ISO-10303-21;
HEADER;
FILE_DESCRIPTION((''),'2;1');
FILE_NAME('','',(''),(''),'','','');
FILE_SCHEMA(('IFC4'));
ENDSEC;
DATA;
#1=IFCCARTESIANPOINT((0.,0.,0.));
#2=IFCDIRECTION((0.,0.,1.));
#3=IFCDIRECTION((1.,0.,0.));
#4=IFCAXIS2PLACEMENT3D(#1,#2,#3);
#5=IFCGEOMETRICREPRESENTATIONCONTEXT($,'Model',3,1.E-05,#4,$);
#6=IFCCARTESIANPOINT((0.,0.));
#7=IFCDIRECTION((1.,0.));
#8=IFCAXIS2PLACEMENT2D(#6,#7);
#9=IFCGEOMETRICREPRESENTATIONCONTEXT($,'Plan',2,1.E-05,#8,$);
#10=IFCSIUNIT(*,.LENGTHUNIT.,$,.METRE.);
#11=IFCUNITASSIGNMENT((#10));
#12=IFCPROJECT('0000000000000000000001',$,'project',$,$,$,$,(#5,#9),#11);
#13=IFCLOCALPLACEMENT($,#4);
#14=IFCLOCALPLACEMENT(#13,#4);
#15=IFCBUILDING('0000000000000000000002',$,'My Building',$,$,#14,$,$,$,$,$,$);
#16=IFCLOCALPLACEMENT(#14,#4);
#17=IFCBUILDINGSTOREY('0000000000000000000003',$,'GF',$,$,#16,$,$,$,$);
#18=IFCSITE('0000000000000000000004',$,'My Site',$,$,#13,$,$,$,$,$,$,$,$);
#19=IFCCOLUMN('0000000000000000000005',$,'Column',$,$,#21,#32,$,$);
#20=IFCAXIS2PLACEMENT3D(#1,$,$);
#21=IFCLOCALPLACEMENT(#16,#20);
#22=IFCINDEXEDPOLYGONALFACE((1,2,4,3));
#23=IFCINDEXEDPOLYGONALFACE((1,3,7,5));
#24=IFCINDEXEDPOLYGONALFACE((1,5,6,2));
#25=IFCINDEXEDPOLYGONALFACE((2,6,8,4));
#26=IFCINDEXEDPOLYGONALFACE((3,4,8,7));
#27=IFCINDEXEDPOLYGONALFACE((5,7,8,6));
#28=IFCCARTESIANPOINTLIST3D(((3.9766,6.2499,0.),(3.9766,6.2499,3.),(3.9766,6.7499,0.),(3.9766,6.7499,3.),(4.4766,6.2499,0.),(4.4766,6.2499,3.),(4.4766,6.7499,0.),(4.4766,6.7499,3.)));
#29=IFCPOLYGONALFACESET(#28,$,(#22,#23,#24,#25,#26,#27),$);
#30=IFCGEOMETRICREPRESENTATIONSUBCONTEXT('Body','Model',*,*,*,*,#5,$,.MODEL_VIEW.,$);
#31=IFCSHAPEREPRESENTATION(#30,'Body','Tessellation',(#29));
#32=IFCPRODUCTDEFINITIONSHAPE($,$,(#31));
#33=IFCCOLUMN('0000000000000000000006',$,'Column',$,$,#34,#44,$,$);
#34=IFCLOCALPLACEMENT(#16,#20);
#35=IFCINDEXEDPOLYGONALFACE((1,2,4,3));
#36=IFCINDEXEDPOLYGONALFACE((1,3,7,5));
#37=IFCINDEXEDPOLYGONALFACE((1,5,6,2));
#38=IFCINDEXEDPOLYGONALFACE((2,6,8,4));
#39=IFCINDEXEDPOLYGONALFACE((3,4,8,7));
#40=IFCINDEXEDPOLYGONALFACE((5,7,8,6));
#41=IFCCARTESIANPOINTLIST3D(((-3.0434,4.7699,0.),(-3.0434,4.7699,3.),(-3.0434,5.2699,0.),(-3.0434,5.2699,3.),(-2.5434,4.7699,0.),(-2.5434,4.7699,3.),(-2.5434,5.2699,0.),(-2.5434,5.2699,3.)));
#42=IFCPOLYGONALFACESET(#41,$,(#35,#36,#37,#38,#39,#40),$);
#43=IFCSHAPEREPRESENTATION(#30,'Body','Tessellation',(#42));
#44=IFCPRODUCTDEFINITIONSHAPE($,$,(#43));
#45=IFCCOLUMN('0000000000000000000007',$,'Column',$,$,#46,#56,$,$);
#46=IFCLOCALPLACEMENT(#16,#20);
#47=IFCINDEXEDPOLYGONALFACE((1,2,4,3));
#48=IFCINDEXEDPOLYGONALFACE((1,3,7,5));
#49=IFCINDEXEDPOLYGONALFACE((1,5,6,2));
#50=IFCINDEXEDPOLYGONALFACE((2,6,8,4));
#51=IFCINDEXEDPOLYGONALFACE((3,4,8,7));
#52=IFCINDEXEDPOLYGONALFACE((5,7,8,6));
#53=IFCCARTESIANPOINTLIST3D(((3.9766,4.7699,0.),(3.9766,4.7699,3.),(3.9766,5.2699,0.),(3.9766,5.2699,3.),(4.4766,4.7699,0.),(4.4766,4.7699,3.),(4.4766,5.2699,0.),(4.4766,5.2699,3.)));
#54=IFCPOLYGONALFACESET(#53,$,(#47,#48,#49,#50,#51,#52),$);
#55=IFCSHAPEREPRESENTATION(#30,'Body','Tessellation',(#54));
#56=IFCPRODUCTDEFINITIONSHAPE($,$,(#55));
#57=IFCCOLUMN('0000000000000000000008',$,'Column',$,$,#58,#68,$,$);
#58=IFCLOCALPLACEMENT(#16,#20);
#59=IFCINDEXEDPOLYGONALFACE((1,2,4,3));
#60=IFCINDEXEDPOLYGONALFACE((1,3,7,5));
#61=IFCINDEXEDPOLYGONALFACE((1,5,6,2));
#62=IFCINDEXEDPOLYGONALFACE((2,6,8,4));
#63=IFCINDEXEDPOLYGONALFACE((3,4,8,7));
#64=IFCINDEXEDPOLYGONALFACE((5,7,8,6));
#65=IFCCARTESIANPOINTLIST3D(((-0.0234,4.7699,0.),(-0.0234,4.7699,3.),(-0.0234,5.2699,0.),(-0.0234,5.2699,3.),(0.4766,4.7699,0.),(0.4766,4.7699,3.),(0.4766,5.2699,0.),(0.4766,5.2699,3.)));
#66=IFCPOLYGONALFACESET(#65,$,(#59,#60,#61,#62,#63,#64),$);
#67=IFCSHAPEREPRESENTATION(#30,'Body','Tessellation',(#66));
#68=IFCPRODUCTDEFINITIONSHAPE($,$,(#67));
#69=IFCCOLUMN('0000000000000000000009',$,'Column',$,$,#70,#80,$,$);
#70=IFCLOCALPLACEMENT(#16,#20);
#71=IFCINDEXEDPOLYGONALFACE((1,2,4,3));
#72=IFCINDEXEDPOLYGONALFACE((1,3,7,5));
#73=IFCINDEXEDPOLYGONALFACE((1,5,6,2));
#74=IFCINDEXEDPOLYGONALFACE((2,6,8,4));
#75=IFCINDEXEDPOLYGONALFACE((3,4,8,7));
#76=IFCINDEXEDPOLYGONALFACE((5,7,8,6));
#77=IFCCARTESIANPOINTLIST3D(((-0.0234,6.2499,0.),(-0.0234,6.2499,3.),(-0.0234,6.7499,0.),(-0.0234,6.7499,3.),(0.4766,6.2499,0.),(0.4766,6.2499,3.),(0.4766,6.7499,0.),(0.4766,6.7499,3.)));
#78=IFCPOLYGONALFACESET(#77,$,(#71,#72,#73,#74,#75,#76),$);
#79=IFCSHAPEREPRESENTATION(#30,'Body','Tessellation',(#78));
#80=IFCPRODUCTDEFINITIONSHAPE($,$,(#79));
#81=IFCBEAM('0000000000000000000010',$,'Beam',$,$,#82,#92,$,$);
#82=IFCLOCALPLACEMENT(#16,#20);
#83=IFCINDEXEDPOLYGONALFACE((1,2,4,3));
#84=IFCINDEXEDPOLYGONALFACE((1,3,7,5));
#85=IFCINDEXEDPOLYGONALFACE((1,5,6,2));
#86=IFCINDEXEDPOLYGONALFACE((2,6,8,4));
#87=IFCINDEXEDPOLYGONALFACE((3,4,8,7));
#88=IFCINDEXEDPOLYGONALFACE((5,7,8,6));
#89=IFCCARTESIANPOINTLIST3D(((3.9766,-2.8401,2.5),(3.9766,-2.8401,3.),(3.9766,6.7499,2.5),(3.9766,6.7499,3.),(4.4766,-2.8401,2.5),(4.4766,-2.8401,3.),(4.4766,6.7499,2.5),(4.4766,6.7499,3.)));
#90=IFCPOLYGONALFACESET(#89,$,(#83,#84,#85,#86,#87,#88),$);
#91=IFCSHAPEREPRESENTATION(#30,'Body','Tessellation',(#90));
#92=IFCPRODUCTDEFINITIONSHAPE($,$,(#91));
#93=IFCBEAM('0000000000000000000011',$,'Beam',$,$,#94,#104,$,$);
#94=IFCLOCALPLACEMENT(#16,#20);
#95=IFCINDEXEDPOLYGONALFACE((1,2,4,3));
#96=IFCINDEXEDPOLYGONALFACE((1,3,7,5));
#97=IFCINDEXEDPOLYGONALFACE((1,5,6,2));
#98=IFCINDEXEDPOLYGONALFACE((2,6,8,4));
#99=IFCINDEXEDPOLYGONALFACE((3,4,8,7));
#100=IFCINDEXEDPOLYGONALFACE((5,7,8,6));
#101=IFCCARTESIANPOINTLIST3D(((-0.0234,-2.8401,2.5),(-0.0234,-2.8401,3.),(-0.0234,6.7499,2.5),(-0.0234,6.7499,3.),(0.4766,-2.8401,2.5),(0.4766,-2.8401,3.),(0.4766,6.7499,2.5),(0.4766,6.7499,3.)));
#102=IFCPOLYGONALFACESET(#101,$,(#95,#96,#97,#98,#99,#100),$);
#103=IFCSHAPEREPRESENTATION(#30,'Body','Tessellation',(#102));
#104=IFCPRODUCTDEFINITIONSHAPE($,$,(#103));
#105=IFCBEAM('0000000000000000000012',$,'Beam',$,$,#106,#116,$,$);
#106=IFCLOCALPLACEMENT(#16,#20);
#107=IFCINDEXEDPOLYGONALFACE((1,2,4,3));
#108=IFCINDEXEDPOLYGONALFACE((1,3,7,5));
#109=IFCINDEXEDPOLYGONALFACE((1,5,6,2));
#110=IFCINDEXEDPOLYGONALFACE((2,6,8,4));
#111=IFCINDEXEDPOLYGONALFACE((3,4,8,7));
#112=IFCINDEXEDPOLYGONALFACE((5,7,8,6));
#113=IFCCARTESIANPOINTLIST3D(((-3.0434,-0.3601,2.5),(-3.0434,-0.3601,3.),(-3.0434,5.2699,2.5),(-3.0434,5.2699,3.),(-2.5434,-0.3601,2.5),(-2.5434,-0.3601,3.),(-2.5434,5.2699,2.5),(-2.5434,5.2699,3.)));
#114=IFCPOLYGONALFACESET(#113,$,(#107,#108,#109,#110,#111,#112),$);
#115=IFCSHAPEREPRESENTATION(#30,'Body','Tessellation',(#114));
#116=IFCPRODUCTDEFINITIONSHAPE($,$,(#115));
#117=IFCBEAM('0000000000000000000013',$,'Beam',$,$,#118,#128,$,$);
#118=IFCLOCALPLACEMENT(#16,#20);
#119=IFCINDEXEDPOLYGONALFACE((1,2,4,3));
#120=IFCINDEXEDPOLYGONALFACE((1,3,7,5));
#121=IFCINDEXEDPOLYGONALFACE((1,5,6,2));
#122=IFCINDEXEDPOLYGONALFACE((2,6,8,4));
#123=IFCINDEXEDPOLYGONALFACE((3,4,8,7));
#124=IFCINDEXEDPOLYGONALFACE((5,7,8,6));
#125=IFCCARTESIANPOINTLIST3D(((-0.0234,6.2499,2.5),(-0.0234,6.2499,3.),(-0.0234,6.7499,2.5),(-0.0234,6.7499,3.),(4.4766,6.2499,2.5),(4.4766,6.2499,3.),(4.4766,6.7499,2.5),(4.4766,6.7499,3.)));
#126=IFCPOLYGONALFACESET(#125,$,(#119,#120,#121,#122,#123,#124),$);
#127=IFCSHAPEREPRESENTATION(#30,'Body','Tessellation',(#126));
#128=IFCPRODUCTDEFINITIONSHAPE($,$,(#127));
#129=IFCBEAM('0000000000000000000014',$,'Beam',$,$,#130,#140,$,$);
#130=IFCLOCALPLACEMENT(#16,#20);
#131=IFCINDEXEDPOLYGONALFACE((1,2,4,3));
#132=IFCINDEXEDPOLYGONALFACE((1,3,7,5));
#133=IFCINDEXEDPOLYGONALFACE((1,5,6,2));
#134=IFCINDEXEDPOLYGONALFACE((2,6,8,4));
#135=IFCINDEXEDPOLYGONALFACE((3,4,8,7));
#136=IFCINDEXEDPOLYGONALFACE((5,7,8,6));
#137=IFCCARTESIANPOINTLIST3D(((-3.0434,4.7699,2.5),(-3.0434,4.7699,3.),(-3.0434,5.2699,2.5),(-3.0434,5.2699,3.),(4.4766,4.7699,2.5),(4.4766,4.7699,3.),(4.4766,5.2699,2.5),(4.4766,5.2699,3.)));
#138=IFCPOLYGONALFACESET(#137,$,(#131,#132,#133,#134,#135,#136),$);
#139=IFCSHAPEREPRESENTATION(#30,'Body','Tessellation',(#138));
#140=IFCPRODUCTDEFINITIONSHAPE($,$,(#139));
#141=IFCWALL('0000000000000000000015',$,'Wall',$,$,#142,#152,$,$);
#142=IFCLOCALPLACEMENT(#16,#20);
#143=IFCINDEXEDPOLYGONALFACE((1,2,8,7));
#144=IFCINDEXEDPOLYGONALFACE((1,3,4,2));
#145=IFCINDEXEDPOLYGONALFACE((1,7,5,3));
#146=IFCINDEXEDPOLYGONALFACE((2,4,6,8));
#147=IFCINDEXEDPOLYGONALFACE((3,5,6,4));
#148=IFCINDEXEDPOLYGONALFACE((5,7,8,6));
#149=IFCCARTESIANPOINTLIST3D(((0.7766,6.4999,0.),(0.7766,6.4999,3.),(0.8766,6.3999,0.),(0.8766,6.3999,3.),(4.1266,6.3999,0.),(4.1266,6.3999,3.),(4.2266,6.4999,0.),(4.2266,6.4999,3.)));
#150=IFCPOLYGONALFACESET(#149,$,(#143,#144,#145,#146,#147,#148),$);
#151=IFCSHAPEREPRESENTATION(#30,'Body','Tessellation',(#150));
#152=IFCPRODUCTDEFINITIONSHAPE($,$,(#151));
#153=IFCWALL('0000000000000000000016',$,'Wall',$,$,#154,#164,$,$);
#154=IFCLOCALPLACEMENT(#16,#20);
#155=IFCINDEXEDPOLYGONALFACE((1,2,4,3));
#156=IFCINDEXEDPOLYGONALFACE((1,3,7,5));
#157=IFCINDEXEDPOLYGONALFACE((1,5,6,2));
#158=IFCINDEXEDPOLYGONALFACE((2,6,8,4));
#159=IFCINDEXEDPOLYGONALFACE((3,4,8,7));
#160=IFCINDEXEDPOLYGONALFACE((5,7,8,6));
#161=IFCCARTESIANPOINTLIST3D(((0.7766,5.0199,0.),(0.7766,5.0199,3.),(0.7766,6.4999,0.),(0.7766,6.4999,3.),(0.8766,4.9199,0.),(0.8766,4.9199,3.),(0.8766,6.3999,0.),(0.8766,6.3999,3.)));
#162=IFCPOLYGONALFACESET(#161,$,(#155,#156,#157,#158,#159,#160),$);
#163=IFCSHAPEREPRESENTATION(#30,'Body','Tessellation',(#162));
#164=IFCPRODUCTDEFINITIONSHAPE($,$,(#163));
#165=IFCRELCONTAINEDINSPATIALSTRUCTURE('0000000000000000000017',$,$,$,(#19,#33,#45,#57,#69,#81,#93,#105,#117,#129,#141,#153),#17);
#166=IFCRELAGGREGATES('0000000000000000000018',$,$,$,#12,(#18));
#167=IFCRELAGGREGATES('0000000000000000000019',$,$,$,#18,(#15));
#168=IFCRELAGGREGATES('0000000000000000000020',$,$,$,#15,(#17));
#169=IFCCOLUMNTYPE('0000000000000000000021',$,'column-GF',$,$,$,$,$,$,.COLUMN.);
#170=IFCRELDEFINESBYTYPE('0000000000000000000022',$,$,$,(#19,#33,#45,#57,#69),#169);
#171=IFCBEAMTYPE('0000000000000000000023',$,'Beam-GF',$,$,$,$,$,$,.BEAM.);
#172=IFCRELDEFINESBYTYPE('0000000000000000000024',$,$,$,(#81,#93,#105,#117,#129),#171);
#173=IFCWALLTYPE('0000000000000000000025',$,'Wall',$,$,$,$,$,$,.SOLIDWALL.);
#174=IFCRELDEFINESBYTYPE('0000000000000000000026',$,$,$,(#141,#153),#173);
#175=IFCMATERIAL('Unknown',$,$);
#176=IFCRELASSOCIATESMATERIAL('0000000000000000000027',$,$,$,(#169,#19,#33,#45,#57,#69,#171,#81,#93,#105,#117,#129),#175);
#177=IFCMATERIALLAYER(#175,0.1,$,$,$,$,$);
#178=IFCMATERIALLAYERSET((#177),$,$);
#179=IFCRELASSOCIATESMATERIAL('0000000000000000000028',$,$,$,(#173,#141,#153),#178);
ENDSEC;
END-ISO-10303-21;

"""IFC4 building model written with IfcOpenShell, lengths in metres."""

from ifc_helpers import new_model, si_unit, frame, origin_with_axes, origin_2d_with_axis, place, context, subcontext, project, spatial, line, indexed_curve, rectangle, outline, extrude, material, layer, layer_set, layer_usage, material_profile, profile_set, profile_usage, type_object, element, save


model = new_model("IFC4")

# Units and contexts
model_context = context("Model", 3, precision=1e-05, world=origin_with_axes())
plan_context = context("Plan", 2, precision=1e-05, world=origin_2d_with_axis())
body_context_1 = subcontext(model_context, "Body", "Model", "MODEL_VIEW")
ifc_project = project(units=[si_unit("LENGTHUNIT", "METRE")], contexts=[model_context, plan_context])

# Site, building, storey
site_placement = place(None, origin_with_axes())
site = spatial("IfcSite", under=ifc_project, at=site_placement, Name="My Site")
building_placement = place(site_placement, origin_with_axes())
building = spatial("IfcBuilding", under=site, at=building_placement, Name="My Building")
storey_placement = place(building_placement, origin_with_axes())
storey = spatial("IfcBuildingStorey", under=building, at=storey_placement, Name="GF")

# Columns
ifc_material_1 = material(Name="Unknown")
ifc_material_profile_1 = material_profile(ifc_material_1, rectangle(XDim=0.5, YDim=0.5))
ifc_profile_set_1 = profile_set([ifc_material_profile_1])
ifc_profile_usage_1 = profile_usage(ifc_profile_set_1, cardinal=5)
column_type = type_object("IfcColumnType", Name="column-GF", PredefinedType="COLUMN", material=ifc_profile_set_1)
column_1_placement = place(storey_placement, frame((4.2266, 6.4999, 0.0), z_axis=(0.0, 0.0, 1.0), x_axis=(1.0, 0.0, 0.0)))
element("IfcColumn", 1, at=column_1_placement, inside=storey, type_object=column_type, material=ifc_profile_usage_1, Name="Column", context=body_context_1, shape_type="SweptSolid", body=[
    extrude(rectangle(XDim=0.5, YDim=0.5), origin_with_axes(), (0.0, 0.0, 1.0), 3.0),
])
ifc_profile_usage_2 = profile_usage(ifc_profile_set_1, cardinal=5)
column_2_placement = place(storey_placement, frame((-2.7934, 5.0199, 0.0), z_axis=(0.0, 0.0, 1.0), x_axis=(1.0, 0.0, 0.0)))
element("IfcColumn", 2, at=column_2_placement, inside=storey, type_object=column_type, material=ifc_profile_usage_2, Name="Column", context=body_context_1, shape_type="SweptSolid", body=[
    extrude(rectangle(XDim=0.5, YDim=0.5), origin_with_axes(), (0.0, 0.0, 1.0), 3.0),
])
ifc_profile_usage_3 = profile_usage(ifc_profile_set_1, cardinal=5)
column_3_placement = place(storey_placement, frame((4.2266, 5.0199, 0.0), z_axis=(0.0, 0.0, 1.0), x_axis=(1.0, 0.0, 0.0)))
element("IfcColumn", 3, at=column_3_placement, inside=storey, type_object=column_type, material=ifc_profile_usage_3, Name="Column", context=body_context_1, shape_type="SweptSolid", body=[
    extrude(rectangle(XDim=0.5, YDim=0.5), origin_with_axes(), (0.0, 0.0, 1.0), 3.0),
])
ifc_profile_usage_4 = profile_usage(ifc_profile_set_1, cardinal=5)
column_4_placement = place(storey_placement, frame((0.2266, 5.0199, 0.0), z_axis=(0.0, 0.0, 1.0), x_axis=(1.0, 0.0, 0.0)))
element("IfcColumn", 4, at=column_4_placement, inside=storey, type_object=column_type, material=ifc_profile_usage_4, Name="Column", context=body_context_1, shape_type="SweptSolid", body=[
    extrude(rectangle(XDim=0.5, YDim=0.5), origin_with_axes(), (0.0, 0.0, 1.0), 3.0),
])
ifc_profile_usage_5 = profile_usage(ifc_profile_set_1, cardinal=5)
column_5_placement = place(storey_placement, frame((0.2266, 6.4999, 0.0), z_axis=(0.0, 0.0, 1.0), x_axis=(1.0, 0.0, 0.0)))
element("IfcColumn", 5, at=column_5_placement, inside=storey, type_object=column_type, material=ifc_profile_usage_5, Name="Column", context=body_context_1, shape_type="SweptSolid", body=[
    extrude(rectangle(XDim=0.5, YDim=0.5), origin_with_axes(), (0.0, 0.0, 1.0), 3.0),
])

# Beams
ifc_material_profile_2 = material_profile(ifc_material_1, rectangle(XDim=0.5, YDim=0.5))
ifc_profile_set_2 = profile_set([ifc_material_profile_2])
ifc_profile_usage_6 = profile_usage(ifc_profile_set_2, cardinal=7)
beam_type = type_object("IfcBeamType", Name="Beam-GF", PredefinedType="BEAM", material=ifc_profile_set_2)
beam_1_placement = place(storey_placement, frame((4.4766, 6.7499, 3.0), z_axis=(0.0, -1.0, 0.0), x_axis=(1.0, 0.0, 0.0)))
element("IfcBeam", 6, at=beam_1_placement, inside=storey, type_object=beam_type, material=ifc_profile_usage_6, Name="Beam", context=body_context_1, shape_type="SweptSolid", body=[
    extrude(rectangle(XDim=0.5, YDim=0.5), frame((-0.25, -0.25, 0.0), z_axis=(0.0, 0.0, 1.0), x_axis=(1.0, 0.0, 0.0)), (0.0, 0.0, 1.0), 9.59),
])
ifc_profile_usage_7 = profile_usage(ifc_profile_set_2, cardinal=7)
beam_2_placement = place(storey_placement, frame((0.4766, 6.7499, 3.0), z_axis=(0.0, -1.0, 0.0), x_axis=(1.0, 0.0, 0.0)))
element("IfcBeam", 7, at=beam_2_placement, inside=storey, type_object=beam_type, material=ifc_profile_usage_7, Name="Beam", context=body_context_1, shape_type="SweptSolid", body=[
    extrude(rectangle(XDim=0.5, YDim=0.5), frame((-0.25, -0.25, 0.0), z_axis=(0.0, 0.0, 1.0), x_axis=(1.0, 0.0, 0.0)), (0.0, 0.0, 1.0), 9.59),
])
ifc_profile_usage_8 = profile_usage(ifc_profile_set_2, cardinal=7)
beam_3_placement = place(storey_placement, frame((-2.5434, 5.2699, 3.0), z_axis=(0.0, -1.0, 0.0), x_axis=(1.0, 0.0, 0.0)))
element("IfcBeam", 8, at=beam_3_placement, inside=storey, type_object=beam_type, material=ifc_profile_usage_8, Name="Beam", context=body_context_1, shape_type="SweptSolid", body=[
    extrude(rectangle(XDim=0.5, YDim=0.5), frame((-0.25, -0.25, 0.0), z_axis=(0.0, 0.0, 1.0), x_axis=(1.0, 0.0, 0.0)), (0.0, 0.0, 1.0), 5.63),
])
ifc_profile_usage_9 = profile_usage(ifc_profile_set_2, cardinal=7)
beam_4_placement = place(storey_placement, frame((4.4766, 6.2499, 3.0), z_axis=(-1.0, 0.0, 0.0), x_axis=(0.0, -1.0, 0.0)))
element("IfcBeam", 9, at=beam_4_placement, inside=storey, type_object=beam_type, material=ifc_profile_usage_9, Name="Beam", context=body_context_1, shape_type="SweptSolid", body=[
    extrude(rectangle(XDim=0.5, YDim=0.5), frame((-0.25, -0.25, 0.0), z_axis=(0.0, 0.0, 1.0), x_axis=(1.0, 0.0, 0.0)), (0.0, 0.0, 1.0), 4.5),
])
ifc_profile_usage_10 = profile_usage(ifc_profile_set_2, cardinal=7)
beam_5_placement = place(storey_placement, frame((4.4766, 4.7699, 3.0), z_axis=(-1.0, 0.0, 0.0), x_axis=(0.0, -1.0, 0.0)))
element("IfcBeam", 10, at=beam_5_placement, inside=storey, type_object=beam_type, material=ifc_profile_usage_10, Name="Beam", context=body_context_1, shape_type="SweptSolid", body=[
    extrude(rectangle(XDim=0.5, YDim=0.5), frame((-0.25, -0.25, 0.0), z_axis=(0.0, 0.0, 1.0), x_axis=(1.0, 0.0, 0.0)), (0.0, 0.0, 1.0), 7.52),
])

# Walls
ifc_layer_1 = layer(ifc_material_1, 0.1)
ifc_layer_set_1 = layer_set([ifc_layer_1])
ifc_layer_usage_1 = layer_usage(ifc_layer_set_1, "AXIS2", "POSITIVE", 0.0)
wall_type = type_object("IfcWallType", Name="Wall", PredefinedType="SOLIDWALL", material=ifc_layer_set_1)
wall_1_placement = place(storey_placement, frame((4.2266, 6.4999, 0.0), z_axis=(0.0, 0.0, 1.0), x_axis=(-1.0, 0.0, 0.0)))
element("IfcWall", 11, at=wall_1_placement, inside=storey, type_object=wall_type, material=ifc_layer_usage_1, Name="Wall", context=body_context_1, shape_type="SweptSolid", body=[
    extrude(outline(indexed_curve([(0.0, 0.0), (0.1, 0.1), (3.35, 0.1), (3.45, 0.0)], segments=[line(1, 2, 3, 4, 1)])), origin_with_axes(), (0.0, 0.0, 1.0), 3.0),
])
ifc_layer_usage_2 = layer_usage(ifc_layer_set_1, "AXIS2", "POSITIVE", 0.0)
wall_2_placement = place(storey_placement, frame((0.7766, 6.4999, 0.0), z_axis=(0.0, 0.0, 1.0), x_axis=(0.0, -1.0, 0.0)))
element("IfcWall", 12, at=wall_2_placement, inside=storey, type_object=wall_type, material=ifc_layer_usage_2, Name="Wall", context=body_context_1, shape_type="SweptSolid", body=[
    extrude(outline(indexed_curve([(0.0, 0.0), (0.1, 0.1), (1.58, 0.1), (1.48, 0.0)], segments=[line(1, 2, 3, 4, 1)])), origin_with_axes(), (0.0, 0.0, 1.0), 3.0),
])

save(model, "model.ifc")
